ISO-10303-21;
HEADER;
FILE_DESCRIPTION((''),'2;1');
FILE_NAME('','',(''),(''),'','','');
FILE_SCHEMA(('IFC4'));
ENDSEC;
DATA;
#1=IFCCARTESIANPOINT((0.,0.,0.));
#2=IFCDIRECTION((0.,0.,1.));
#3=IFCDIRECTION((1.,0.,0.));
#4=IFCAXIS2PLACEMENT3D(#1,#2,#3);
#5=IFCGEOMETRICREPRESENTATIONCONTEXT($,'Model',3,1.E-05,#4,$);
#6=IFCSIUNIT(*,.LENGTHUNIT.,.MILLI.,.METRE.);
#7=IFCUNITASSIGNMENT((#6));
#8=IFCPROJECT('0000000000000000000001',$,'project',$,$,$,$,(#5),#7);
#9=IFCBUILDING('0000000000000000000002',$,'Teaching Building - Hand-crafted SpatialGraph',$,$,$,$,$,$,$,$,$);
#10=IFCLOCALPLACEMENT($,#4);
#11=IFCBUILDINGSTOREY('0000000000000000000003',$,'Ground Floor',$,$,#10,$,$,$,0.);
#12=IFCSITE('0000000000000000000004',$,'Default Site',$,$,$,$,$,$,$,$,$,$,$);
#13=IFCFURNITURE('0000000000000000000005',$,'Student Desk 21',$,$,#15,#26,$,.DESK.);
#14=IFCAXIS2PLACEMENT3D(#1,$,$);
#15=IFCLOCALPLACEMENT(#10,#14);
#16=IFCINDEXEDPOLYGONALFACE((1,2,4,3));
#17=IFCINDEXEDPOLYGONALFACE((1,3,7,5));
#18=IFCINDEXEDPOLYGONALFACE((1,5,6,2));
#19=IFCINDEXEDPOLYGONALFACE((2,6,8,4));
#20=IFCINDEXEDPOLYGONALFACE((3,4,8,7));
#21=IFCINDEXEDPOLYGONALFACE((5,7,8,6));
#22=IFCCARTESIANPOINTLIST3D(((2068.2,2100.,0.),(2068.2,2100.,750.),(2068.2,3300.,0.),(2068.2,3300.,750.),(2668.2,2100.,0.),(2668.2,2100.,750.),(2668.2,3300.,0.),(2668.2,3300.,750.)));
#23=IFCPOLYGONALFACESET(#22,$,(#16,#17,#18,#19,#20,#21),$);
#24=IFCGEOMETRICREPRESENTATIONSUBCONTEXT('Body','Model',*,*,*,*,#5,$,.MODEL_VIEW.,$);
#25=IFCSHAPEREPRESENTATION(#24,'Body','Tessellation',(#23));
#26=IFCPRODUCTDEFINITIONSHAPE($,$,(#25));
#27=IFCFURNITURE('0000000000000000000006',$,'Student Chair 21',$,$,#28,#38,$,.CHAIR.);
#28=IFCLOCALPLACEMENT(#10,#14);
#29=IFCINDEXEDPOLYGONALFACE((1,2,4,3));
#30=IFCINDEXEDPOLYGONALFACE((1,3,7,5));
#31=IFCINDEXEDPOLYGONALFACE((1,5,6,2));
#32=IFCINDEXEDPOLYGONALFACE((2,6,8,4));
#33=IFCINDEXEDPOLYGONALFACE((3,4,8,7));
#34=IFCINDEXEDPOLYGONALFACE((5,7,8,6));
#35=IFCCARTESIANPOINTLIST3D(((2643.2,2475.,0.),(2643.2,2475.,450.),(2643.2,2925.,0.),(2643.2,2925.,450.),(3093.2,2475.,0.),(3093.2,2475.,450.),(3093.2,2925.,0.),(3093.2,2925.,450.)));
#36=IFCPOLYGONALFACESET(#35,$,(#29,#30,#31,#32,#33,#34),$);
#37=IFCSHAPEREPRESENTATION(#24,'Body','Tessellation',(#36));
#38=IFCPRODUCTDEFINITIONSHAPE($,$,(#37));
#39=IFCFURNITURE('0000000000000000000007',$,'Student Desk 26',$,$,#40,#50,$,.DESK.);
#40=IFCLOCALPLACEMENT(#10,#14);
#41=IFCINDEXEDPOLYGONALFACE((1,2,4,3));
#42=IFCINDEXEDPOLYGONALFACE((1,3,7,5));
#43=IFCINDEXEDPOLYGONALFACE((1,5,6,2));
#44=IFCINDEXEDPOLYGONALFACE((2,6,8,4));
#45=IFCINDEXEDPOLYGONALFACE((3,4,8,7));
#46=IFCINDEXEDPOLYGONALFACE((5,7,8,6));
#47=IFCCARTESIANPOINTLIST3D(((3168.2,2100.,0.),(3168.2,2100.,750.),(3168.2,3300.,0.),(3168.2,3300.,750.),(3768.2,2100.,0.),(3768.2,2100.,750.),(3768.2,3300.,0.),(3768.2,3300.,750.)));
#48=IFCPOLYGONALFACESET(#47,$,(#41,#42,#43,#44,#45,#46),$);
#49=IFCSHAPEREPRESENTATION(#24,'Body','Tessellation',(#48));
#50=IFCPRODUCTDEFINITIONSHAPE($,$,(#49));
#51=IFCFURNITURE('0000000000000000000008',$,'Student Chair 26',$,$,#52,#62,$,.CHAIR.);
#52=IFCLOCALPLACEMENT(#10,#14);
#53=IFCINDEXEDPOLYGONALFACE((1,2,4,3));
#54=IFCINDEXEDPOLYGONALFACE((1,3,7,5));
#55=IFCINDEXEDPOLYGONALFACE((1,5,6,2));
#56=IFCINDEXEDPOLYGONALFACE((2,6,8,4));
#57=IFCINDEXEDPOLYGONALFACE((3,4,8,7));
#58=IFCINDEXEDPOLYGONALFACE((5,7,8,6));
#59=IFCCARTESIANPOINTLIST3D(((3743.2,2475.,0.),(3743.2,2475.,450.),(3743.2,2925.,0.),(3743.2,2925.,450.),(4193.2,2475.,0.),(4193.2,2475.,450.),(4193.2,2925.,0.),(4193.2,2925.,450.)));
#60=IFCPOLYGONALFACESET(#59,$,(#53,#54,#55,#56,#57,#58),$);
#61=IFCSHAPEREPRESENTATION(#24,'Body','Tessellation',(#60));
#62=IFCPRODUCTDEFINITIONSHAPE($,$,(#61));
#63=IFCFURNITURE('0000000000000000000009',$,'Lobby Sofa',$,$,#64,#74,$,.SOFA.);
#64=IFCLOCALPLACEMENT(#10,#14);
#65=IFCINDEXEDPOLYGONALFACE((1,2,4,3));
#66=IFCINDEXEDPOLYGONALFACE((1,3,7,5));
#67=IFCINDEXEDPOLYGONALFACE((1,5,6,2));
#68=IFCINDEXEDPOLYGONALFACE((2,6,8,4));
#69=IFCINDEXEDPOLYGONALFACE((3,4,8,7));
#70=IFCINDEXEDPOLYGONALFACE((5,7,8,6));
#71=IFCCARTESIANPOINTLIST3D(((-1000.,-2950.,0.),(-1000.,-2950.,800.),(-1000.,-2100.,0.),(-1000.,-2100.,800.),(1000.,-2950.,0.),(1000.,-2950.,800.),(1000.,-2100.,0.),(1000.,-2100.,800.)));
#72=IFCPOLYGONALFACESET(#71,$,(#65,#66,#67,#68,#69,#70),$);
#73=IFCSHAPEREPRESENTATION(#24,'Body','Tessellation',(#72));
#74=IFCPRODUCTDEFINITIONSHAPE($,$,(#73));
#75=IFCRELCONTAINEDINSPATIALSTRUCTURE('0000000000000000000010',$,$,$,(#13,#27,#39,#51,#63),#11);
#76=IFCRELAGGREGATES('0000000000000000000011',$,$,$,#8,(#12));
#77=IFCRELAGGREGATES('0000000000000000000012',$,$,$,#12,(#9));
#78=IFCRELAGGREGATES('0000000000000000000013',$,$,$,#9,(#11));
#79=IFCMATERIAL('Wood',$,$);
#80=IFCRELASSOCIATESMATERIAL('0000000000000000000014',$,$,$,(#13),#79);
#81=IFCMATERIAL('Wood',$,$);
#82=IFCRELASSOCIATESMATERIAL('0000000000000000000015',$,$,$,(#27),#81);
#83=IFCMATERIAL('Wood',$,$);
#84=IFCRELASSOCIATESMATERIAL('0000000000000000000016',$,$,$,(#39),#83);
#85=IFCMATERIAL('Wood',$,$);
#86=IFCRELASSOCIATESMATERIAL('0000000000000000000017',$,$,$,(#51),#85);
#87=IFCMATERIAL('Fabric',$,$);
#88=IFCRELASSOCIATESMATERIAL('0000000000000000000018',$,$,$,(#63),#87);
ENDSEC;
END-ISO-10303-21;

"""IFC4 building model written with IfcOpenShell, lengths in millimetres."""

from ifc_helpers import new_model, si_unit, frame, origin_with_axes, origin_2d, place, context, subcontext, project, spatial, rectangle, extrude, material, element, save


model = new_model("IFC4")

# Units and contexts
model_context = context("Model", 3, precision=1e-05, world=origin_with_axes())
body_context = subcontext(model_context, "Body", "Model", "MODEL_VIEW")
ifc_project = project(units=[si_unit("LENGTHUNIT", "METRE", prefix="MILLI")], contexts=[model_context])

# Site, building, storey
site = spatial("IfcSite", under=ifc_project, Name="Default Site")
building = spatial("IfcBuilding", under=site, Name="Teaching Building - Hand-crafted SpatialGraph")
storey_placement = place(None, origin_with_axes())
storey = spatial("IfcBuildingStorey", under=building, at=storey_placement, Name="Ground Floor", Elevation=0.0)

# Furniture
ifc_material_1 = material(Name="Wood")
furniture_1_placement = place(storey_placement, frame((2368.2, 2700.0, 0.0), z_axis=(0.0, 0.0, 1.0), x_axis=(0.0, 1.0, 0.0)))
element("IfcFurniture", 1, at=furniture_1_placement, inside=storey, material=ifc_material_1, Name="Student Desk 21", PredefinedType="DESK", context=body_context, shape_type="SweptSolid", body=[
    extrude(rectangle(XDim=1200.0, YDim=600.0, at=origin_2d()), origin_with_axes(), (0.0, 0.0, 1.0), 750.0),
])
ifc_material_2 = material(Name="Wood")
furniture_2_placement = place(storey_placement, frame((2868.2, 2700.0, 0.0), z_axis=(0.0, 0.0, 1.0), x_axis=(1.0, 0.0, 0.0)))
element("IfcFurniture", 2, at=furniture_2_placement, inside=storey, material=ifc_material_2, Name="Student Chair 21", PredefinedType="CHAIR", context=body_context, shape_type="SweptSolid", body=[
    extrude(rectangle(XDim=450.0, YDim=450.0, at=origin_2d()), origin_with_axes(), (0.0, 0.0, 1.0), 450.0),
])
ifc_material_3 = material(Name="Wood")
furniture_3_placement = place(storey_placement, frame((3468.2, 2700.0, 0.0), z_axis=(0.0, 0.0, 1.0), x_axis=(0.0, 1.0, 0.0)))
element("IfcFurniture", 3, at=furniture_3_placement, inside=storey, material=ifc_material_3, Name="Student Desk 26", PredefinedType="DESK", context=body_context, shape_type="SweptSolid", body=[
    extrude(rectangle(XDim=1200.0, YDim=600.0, at=origin_2d()), origin_with_axes(), (0.0, 0.0, 1.0), 750.0),
])
ifc_material_4 = material(Name="Wood")
furniture_4_placement = place(storey_placement, frame((3968.2, 2700.0, 0.0), z_axis=(0.0, 0.0, 1.0), x_axis=(1.0, 0.0, 0.0)))
element("IfcFurniture", 4, at=furniture_4_placement, inside=storey, material=ifc_material_4, Name="Student Chair 26", PredefinedType="CHAIR", context=body_context, shape_type="SweptSolid", body=[
    extrude(rectangle(XDim=450.0, YDim=450.0, at=origin_2d()), origin_with_axes(), (0.0, 0.0, 1.0), 450.0),
])
ifc_material_5 = material(Name="Fabric")
furniture_5_placement = place(storey_placement, frame((0.0, -2525.0, 0.0), z_axis=(0.0, 0.0, 1.0), x_axis=(1.0, 0.0, 0.0)))
element("IfcFurniture", 5, at=furniture_5_placement, inside=storey, material=ifc_material_5, Name="Lobby Sofa", PredefinedType="SOFA", context=body_context, shape_type="SweptSolid", body=[
    extrude(rectangle(XDim=2000.0, YDim=850.0, at=origin_2d()), origin_with_axes(), (0.0, 0.0, 1.0), 800.0),
])

save(model, "model.ifc")
